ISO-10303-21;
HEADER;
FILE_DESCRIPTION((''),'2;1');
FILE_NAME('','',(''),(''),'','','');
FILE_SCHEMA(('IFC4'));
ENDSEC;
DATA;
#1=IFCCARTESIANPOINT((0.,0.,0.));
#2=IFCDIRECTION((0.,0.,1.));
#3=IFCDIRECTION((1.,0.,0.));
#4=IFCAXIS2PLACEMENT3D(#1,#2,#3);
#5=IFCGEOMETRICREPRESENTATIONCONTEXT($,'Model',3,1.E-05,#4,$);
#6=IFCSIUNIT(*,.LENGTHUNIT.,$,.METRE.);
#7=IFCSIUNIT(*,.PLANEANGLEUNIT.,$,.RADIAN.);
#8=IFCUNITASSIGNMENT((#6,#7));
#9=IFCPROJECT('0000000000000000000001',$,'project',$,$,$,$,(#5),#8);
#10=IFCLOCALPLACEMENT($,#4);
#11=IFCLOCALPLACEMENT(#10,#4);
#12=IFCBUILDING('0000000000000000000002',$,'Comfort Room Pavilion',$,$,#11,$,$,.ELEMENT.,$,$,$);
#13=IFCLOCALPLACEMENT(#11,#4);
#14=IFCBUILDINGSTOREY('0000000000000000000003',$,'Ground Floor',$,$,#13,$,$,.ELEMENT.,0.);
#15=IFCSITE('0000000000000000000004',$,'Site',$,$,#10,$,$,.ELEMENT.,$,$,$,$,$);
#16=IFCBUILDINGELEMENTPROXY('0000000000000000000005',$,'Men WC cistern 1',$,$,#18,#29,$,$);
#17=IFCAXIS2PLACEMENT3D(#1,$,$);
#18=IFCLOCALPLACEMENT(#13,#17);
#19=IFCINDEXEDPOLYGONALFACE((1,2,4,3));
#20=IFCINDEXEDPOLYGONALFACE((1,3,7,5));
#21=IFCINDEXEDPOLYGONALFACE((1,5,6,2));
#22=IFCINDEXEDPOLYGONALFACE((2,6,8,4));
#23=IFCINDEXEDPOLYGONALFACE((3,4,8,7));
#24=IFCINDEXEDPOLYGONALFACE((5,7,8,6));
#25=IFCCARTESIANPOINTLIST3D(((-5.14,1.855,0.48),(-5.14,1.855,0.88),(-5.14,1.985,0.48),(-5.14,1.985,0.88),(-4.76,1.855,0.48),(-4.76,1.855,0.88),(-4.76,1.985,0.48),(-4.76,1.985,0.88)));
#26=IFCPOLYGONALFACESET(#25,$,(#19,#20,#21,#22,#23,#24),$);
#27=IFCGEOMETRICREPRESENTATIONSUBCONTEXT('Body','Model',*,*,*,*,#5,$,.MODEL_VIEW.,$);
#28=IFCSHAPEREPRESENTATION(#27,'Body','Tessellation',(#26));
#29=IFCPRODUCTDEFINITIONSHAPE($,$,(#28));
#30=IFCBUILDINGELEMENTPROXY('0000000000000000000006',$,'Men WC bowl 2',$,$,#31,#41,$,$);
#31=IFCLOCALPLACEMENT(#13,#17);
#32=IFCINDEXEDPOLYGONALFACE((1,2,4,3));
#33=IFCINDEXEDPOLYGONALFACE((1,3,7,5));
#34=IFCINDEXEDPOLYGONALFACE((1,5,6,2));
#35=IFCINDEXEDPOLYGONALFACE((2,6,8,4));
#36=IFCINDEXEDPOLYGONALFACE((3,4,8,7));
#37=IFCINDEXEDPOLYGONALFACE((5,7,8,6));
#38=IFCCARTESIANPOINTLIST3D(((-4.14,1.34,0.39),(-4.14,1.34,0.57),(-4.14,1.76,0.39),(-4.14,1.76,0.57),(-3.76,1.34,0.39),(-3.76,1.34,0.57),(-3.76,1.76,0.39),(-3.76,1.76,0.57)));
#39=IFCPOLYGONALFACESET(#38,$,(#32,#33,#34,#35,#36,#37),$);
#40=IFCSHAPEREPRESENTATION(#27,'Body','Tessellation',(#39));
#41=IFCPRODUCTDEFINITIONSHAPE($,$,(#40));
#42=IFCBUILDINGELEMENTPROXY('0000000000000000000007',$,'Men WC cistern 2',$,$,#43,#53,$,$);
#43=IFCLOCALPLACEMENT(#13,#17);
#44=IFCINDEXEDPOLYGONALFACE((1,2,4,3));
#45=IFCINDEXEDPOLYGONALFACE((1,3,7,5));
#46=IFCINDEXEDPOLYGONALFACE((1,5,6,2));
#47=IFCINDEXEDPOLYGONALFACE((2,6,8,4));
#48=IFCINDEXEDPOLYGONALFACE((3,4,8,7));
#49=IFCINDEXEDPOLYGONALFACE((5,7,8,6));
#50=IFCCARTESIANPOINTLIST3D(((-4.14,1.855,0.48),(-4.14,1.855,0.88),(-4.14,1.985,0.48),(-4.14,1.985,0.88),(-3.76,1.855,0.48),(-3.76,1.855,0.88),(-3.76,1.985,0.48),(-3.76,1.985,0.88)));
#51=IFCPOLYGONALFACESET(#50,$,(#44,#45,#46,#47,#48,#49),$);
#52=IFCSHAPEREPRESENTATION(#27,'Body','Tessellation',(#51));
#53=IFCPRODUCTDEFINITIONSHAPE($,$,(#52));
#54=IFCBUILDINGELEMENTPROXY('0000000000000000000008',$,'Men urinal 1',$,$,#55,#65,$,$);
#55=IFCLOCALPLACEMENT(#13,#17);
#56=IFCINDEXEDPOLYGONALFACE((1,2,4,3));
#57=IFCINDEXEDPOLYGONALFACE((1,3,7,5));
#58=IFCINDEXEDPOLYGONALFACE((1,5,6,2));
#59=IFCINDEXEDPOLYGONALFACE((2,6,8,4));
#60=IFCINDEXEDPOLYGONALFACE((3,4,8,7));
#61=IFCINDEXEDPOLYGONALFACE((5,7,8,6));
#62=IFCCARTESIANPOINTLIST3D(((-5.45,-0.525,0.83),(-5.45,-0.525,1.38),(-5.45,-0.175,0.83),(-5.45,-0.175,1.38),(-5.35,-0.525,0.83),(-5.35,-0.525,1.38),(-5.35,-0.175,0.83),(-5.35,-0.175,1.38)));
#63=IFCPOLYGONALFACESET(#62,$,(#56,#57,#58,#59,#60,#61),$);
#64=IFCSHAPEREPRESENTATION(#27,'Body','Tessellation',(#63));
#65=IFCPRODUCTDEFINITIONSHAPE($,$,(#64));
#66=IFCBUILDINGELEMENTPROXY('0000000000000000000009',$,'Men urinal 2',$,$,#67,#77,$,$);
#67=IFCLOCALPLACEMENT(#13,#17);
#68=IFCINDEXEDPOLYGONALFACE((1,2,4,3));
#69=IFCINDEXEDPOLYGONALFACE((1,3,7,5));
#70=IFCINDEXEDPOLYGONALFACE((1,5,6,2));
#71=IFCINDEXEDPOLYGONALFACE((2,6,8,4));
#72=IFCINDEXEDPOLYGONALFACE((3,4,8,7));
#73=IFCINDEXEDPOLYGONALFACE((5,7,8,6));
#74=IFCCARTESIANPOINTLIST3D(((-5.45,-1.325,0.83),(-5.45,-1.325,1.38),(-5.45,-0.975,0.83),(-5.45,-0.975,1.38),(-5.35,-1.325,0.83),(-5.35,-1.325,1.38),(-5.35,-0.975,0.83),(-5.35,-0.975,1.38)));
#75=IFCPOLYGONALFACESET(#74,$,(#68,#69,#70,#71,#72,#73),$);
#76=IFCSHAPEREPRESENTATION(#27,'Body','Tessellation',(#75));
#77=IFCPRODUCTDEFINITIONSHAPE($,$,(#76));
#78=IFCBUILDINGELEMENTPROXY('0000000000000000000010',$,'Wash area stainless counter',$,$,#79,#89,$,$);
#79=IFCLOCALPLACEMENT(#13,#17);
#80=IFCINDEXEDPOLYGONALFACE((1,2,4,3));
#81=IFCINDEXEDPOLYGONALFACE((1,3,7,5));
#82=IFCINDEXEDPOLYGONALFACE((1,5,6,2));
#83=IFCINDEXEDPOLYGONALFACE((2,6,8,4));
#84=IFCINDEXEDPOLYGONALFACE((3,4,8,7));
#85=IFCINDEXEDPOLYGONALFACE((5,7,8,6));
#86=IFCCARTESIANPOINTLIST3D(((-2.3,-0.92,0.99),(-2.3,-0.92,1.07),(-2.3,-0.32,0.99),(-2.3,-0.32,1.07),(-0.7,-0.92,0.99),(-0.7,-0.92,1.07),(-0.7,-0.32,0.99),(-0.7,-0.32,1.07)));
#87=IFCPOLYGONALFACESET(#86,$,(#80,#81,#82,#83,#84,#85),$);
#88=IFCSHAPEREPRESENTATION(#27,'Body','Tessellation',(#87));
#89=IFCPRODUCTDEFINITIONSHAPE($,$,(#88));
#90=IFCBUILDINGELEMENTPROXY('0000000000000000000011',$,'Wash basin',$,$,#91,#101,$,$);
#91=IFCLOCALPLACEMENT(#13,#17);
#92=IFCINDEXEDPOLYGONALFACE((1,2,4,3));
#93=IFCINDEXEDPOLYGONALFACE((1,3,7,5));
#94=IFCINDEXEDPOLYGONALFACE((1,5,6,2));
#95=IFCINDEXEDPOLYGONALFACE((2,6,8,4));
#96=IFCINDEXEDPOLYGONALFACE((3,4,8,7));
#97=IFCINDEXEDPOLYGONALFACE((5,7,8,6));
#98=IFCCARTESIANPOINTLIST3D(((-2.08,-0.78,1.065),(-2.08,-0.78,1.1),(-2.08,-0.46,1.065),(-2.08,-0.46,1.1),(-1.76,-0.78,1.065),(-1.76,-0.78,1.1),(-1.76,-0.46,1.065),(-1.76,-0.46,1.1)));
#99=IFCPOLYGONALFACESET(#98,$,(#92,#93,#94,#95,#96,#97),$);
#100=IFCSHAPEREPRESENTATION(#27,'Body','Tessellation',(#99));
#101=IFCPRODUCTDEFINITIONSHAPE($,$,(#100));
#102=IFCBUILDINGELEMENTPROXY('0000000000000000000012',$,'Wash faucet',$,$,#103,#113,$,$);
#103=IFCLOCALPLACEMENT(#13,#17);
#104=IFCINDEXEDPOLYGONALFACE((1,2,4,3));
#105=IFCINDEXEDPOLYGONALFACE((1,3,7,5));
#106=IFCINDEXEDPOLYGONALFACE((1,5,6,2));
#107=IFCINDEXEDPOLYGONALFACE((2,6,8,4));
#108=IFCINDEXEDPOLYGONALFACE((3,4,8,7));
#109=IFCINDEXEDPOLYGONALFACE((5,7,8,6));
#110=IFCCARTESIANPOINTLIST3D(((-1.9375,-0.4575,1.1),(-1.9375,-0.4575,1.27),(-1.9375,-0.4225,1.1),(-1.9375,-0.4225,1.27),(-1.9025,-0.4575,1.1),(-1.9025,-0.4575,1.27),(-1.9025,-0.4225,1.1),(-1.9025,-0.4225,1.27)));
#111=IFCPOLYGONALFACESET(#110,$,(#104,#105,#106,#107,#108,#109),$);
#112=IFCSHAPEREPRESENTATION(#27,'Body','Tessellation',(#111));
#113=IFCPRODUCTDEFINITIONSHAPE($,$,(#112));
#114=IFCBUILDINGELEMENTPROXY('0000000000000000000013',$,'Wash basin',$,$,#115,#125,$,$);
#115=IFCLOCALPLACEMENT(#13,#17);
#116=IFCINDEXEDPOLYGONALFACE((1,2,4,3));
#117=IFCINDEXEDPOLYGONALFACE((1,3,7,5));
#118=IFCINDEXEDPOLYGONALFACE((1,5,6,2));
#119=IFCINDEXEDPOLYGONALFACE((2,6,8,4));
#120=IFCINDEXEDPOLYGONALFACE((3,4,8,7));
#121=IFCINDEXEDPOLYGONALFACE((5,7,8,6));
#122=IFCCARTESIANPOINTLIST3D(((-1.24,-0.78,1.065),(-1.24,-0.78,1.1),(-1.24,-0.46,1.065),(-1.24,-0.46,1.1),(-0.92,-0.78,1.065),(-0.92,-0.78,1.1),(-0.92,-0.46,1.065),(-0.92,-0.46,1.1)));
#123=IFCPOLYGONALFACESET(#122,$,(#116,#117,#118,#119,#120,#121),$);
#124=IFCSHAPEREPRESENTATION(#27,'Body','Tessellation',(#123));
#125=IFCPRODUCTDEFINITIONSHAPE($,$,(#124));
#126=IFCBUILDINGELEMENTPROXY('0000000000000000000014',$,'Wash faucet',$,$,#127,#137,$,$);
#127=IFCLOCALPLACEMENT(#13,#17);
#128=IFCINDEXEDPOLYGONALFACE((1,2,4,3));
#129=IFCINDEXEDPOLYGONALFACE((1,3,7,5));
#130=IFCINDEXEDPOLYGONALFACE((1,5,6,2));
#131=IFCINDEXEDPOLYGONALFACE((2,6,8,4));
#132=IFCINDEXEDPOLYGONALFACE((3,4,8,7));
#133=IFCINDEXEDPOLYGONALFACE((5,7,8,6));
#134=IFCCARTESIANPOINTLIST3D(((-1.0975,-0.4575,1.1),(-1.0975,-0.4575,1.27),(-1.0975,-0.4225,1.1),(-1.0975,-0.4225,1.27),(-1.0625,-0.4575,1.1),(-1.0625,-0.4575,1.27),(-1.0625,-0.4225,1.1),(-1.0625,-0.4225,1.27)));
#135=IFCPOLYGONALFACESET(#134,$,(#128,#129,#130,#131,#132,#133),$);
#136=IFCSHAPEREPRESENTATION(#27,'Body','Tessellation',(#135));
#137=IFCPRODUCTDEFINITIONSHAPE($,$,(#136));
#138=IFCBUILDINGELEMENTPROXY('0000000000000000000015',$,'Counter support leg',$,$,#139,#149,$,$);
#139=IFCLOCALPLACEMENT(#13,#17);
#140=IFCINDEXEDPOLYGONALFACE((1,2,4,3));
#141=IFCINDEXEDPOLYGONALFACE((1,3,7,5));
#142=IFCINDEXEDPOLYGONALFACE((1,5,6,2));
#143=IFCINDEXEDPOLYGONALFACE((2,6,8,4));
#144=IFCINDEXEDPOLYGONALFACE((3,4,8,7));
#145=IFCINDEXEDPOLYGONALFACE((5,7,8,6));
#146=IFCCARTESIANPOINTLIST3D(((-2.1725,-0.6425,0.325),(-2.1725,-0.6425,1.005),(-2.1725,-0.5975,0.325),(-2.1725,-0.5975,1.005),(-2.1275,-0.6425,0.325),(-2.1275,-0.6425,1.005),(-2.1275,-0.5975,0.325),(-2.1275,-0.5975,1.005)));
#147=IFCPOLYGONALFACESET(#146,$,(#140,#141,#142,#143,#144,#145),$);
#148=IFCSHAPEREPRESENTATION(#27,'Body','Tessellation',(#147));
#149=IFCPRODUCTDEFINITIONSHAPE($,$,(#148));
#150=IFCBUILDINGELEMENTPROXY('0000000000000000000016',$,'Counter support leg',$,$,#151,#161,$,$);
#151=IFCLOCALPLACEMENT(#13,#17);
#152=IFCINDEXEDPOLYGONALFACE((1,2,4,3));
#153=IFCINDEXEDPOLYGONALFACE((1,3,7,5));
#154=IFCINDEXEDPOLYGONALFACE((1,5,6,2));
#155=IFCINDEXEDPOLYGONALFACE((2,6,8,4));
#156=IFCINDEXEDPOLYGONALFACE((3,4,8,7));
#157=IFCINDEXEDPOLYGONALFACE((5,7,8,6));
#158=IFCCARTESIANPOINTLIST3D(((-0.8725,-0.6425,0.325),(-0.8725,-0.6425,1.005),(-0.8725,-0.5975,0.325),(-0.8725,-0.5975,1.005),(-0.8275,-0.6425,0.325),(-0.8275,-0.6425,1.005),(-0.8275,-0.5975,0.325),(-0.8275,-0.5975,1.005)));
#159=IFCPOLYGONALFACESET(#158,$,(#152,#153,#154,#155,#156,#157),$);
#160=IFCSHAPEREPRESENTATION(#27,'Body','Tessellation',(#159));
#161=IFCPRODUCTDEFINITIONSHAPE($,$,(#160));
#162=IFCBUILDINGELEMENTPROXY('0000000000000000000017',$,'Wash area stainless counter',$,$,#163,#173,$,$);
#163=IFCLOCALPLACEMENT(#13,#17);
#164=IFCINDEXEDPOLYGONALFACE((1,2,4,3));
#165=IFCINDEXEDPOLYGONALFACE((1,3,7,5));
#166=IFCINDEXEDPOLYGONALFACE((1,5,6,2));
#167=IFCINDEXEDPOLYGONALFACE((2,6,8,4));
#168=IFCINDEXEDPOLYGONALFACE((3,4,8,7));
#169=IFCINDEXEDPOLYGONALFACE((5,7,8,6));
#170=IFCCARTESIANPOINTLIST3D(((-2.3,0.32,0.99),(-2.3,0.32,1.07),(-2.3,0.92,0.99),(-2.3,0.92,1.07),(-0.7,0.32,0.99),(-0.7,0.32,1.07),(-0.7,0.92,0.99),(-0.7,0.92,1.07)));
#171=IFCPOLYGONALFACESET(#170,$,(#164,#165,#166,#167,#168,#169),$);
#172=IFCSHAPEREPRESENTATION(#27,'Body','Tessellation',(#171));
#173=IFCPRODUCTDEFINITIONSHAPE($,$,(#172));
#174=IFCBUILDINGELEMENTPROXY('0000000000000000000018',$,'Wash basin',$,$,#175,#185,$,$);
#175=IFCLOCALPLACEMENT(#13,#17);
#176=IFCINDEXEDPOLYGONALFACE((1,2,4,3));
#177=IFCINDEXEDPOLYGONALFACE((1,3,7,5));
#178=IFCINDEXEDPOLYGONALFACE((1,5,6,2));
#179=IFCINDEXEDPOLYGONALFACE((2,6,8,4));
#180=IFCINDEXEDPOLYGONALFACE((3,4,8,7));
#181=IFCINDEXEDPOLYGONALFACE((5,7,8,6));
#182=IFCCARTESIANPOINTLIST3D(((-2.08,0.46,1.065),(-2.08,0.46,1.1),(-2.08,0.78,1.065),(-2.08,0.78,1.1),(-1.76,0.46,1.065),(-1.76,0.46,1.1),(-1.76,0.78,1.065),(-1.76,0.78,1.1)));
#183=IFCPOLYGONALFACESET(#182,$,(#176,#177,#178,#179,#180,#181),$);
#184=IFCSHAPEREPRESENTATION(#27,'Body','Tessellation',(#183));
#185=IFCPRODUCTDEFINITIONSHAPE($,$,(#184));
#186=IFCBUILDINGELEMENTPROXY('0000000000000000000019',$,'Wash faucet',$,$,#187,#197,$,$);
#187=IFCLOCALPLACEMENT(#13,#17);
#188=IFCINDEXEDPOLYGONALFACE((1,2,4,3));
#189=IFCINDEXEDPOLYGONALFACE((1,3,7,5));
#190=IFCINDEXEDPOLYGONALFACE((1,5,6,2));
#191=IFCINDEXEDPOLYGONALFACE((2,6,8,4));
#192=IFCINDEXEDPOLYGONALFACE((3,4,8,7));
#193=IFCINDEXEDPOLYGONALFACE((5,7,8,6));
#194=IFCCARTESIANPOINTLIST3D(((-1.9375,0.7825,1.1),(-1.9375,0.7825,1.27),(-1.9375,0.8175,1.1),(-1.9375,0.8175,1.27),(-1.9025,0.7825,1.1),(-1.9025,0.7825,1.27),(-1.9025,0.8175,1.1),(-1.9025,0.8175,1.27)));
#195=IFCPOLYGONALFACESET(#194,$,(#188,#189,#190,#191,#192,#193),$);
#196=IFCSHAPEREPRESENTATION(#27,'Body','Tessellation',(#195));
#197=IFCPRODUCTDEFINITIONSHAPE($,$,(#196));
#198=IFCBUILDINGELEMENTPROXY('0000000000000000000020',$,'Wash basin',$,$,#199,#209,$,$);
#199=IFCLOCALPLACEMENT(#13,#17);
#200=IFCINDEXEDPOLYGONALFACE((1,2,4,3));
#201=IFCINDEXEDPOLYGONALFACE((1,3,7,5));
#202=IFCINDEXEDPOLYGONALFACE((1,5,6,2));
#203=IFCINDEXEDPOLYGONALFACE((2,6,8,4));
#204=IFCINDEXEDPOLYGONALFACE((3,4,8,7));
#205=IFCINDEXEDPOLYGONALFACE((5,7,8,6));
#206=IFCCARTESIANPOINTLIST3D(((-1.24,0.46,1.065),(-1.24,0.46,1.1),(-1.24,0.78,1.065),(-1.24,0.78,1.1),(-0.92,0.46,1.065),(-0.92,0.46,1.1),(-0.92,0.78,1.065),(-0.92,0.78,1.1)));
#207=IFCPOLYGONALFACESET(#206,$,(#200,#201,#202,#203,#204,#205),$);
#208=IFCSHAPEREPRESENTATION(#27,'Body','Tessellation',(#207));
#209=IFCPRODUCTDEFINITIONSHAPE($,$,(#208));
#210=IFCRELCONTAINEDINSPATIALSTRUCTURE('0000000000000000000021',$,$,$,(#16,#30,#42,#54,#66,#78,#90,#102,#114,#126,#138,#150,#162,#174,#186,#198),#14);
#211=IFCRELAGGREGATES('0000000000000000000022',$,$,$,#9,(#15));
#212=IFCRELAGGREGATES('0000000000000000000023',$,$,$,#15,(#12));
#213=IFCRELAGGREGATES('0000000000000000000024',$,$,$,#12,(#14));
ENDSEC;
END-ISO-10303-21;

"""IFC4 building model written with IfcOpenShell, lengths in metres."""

from ifc_helpers import new_model, si_unit, frame, origin_with_axes, origin_2d, place, context, subcontext, project, spatial, rectangle, extrude, element, save


model = new_model("IFC4")

# Units and contexts
model_context = context("Model", 3, precision=1e-05, world=origin_with_axes())
body_context = subcontext(model_context, "Body", "Model", "MODEL_VIEW")
ifc_project = project(units=[si_unit("LENGTHUNIT", "METRE"), si_unit("PLANEANGLEUNIT", "RADIAN")], contexts=[model_context])

# Site, building, storey
site_placement = place(None, origin_with_axes())
site = spatial("IfcSite", under=ifc_project, at=site_placement, Name="Site", CompositionType="ELEMENT")
building_placement = place(site_placement, origin_with_axes())
building = spatial("IfcBuilding", under=site, at=building_placement, Name="Comfort Room Pavilion", CompositionType="ELEMENT")
storey_placement = place(building_placement, origin_with_axes())
storey = spatial("IfcBuildingStorey", under=building, at=storey_placement, Name="Ground Floor", CompositionType="ELEMENT", Elevation=0.0)

# Building element proxies
proxy_1_placement = place(storey_placement, frame((-4.95, 1.92, 0.48), z_axis=(0.0, 0.0, 1.0), x_axis=(1.0, 0.0, 0.0)))
element("IfcBuildingElementProxy", 1, at=proxy_1_placement, inside=storey, Name="Men WC cistern 1", context=body_context, shape_type="SweptSolid", body=[
    extrude(rectangle(XDim=0.38, YDim=0.13, at=origin_2d()), origin_with_axes(), (0.0, 0.0, 1.0), 0.4),
])
proxy_2_placement = place(storey_placement, frame((-3.95, 1.55, 0.39), z_axis=(0.0, 0.0, 1.0), x_axis=(1.0, 0.0, 0.0)))
element("IfcBuildingElementProxy", 2, at=proxy_2_placement, inside=storey, Name="Men WC bowl 2", context=body_context, shape_type="SweptSolid", body=[
    extrude(rectangle(XDim=0.38, YDim=0.42, at=origin_2d()), origin_with_axes(), (0.0, 0.0, 1.0), 0.18),
])
proxy_3_placement = place(storey_placement, frame((-3.95, 1.92, 0.48), z_axis=(0.0, 0.0, 1.0), x_axis=(1.0, 0.0, 0.0)))
element("IfcBuildingElementProxy", 3, at=proxy_3_placement, inside=storey, Name="Men WC cistern 2", context=body_context, shape_type="SweptSolid", body=[
    extrude(rectangle(XDim=0.38, YDim=0.13, at=origin_2d()), origin_with_axes(), (0.0, 0.0, 1.0), 0.4),
])
for number, where, z_axis, x_axis, name in (
    (4, (-5.4, -0.35, 0.83), (0.0, 0.0, 1.0), (1.0, 0.0, 0.0), "Men urinal 1"),
    (5, (-5.4, -1.15, 0.83), (0.0, 0.0, 1.0), (1.0, 0.0, 0.0), "Men urinal 2"),
):
    element("IfcBuildingElementProxy", number, at=place(storey_placement, frame(where, z_axis=z_axis, x_axis=x_axis)), inside=storey, Name=name, context=body_context, shape_type="SweptSolid", body=[
        extrude(rectangle(XDim=0.1, YDim=0.35, at=origin_2d()), origin_with_axes(), (0.0, 0.0, 1.0), 0.55),
    ])
proxy_4_placement = place(storey_placement, frame((-1.5, -0.62, 0.99), z_axis=(0.0, 0.0, 1.0), x_axis=(1.0, 0.0, 0.0)))
element("IfcBuildingElementProxy", 6, at=proxy_4_placement, inside=storey, Name="Wash area stainless counter", context=body_context, shape_type="SweptSolid", body=[
    extrude(rectangle(XDim=1.6, YDim=0.6, at=origin_2d()), origin_with_axes(), (0.0, 0.0, 1.0), 0.08),
])
proxy_5_placement = place(storey_placement, frame((-1.92, -0.62, 1.065), z_axis=(0.0, 0.0, 1.0), x_axis=(1.0, 0.0, 0.0)))
element("IfcBuildingElementProxy", 7, at=proxy_5_placement, inside=storey, Name="Wash basin", context=body_context, shape_type="SweptSolid", body=[
    extrude(rectangle(XDim=0.32, YDim=0.32, at=origin_2d()), origin_with_axes(), (0.0, 0.0, 1.0), 0.035),
])
proxy_6_placement = place(storey_placement, frame((-1.92, -0.44, 1.1), z_axis=(0.0, 0.0, 1.0), x_axis=(1.0, 0.0, 0.0)))
element("IfcBuildingElementProxy", 8, at=proxy_6_placement, inside=storey, Name="Wash faucet", context=body_context, shape_type="SweptSolid", body=[
    extrude(rectangle(XDim=0.035, YDim=0.035, at=origin_2d()), origin_with_axes(), (0.0, 0.0, 1.0), 0.17),
])
proxy_7_placement = place(storey_placement, frame((-1.08, -0.62, 1.065), z_axis=(0.0, 0.0, 1.0), x_axis=(1.0, 0.0, 0.0)))
element("IfcBuildingElementProxy", 9, at=proxy_7_placement, inside=storey, Name="Wash basin", context=body_context, shape_type="SweptSolid", body=[
    extrude(rectangle(XDim=0.32, YDim=0.32, at=origin_2d()), origin_with_axes(), (0.0, 0.0, 1.0), 0.035),
])
proxy_8_placement = place(storey_placement, frame((-1.08, -0.44, 1.1), z_axis=(0.0, 0.0, 1.0), x_axis=(1.0, 0.0, 0.0)))
element("IfcBuildingElementProxy", 10, at=proxy_8_placement, inside=storey, Name="Wash faucet", context=body_context, shape_type="SweptSolid", body=[
    extrude(rectangle(XDim=0.035, YDim=0.035, at=origin_2d()), origin_with_axes(), (0.0, 0.0, 1.0), 0.17),
])
for number, where, z_axis, x_axis, name in (
    (11, (-2.15, -0.62, 0.325), (0.0, 0.0, 1.0), (1.0, 0.0, 0.0), "Counter support leg"),
    (12, (-0.85, -0.62, 0.325), (0.0, 0.0, 1.0), (1.0, 0.0, 0.0), "Counter support leg"),
):
    element("IfcBuildingElementProxy", number, at=place(storey_placement, frame(where, z_axis=z_axis, x_axis=x_axis)), inside=storey, Name=name, context=body_context, shape_type="SweptSolid", body=[
        extrude(rectangle(XDim=0.045, YDim=0.045, at=origin_2d()), origin_with_axes(), (0.0, 0.0, 1.0), 0.68),
    ])
proxy_9_placement = place(storey_placement, frame((-1.5, 0.62, 0.99), z_axis=(0.0, 0.0, 1.0), x_axis=(1.0, 0.0, 0.0)))
element("IfcBuildingElementProxy", 13, at=proxy_9_placement, inside=storey, Name="Wash area stainless counter", context=body_context, shape_type="SweptSolid", body=[
    extrude(rectangle(XDim=1.6, YDim=0.6, at=origin_2d()), origin_with_axes(), (0.0, 0.0, 1.0), 0.08),
])
proxy_10_placement = place(storey_placement, frame((-1.92, 0.62, 1.065), z_axis=(0.0, 0.0, 1.0), x_axis=(1.0, 0.0, 0.0)))
element("IfcBuildingElementProxy", 14, at=proxy_10_placement, inside=storey, Name="Wash basin", context=body_context, shape_type="SweptSolid", body=[
    extrude(rectangle(XDim=0.32, YDim=0.32, at=origin_2d()), origin_with_axes(), (0.0, 0.0, 1.0), 0.035),
])
proxy_11_placement = place(storey_placement, frame((-1.92, 0.8, 1.1), z_axis=(0.0, 0.0, 1.0), x_axis=(1.0, 0.0, 0.0)))
element("IfcBuildingElementProxy", 15, at=proxy_11_placement, inside=storey, Name="Wash faucet", context=body_context, shape_type="SweptSolid", body=[
    extrude(rectangle(XDim=0.035, YDim=0.035, at=origin_2d()), origin_with_axes(), (0.0, 0.0, 1.0), 0.17),
])
proxy_12_placement = place(storey_placement, frame((-1.08, 0.62, 1.065), z_axis=(0.0, 0.0, 1.0), x_axis=(1.0, 0.0, 0.0)))
element("IfcBuildingElementProxy", 16, at=proxy_12_placement, inside=storey, Name="Wash basin", context=body_context, shape_type="SweptSolid", body=[
    extrude(rectangle(XDim=0.32, YDim=0.32, at=origin_2d()), origin_with_axes(), (0.0, 0.0, 1.0), 0.035),
])

save(model, "model.ifc")
